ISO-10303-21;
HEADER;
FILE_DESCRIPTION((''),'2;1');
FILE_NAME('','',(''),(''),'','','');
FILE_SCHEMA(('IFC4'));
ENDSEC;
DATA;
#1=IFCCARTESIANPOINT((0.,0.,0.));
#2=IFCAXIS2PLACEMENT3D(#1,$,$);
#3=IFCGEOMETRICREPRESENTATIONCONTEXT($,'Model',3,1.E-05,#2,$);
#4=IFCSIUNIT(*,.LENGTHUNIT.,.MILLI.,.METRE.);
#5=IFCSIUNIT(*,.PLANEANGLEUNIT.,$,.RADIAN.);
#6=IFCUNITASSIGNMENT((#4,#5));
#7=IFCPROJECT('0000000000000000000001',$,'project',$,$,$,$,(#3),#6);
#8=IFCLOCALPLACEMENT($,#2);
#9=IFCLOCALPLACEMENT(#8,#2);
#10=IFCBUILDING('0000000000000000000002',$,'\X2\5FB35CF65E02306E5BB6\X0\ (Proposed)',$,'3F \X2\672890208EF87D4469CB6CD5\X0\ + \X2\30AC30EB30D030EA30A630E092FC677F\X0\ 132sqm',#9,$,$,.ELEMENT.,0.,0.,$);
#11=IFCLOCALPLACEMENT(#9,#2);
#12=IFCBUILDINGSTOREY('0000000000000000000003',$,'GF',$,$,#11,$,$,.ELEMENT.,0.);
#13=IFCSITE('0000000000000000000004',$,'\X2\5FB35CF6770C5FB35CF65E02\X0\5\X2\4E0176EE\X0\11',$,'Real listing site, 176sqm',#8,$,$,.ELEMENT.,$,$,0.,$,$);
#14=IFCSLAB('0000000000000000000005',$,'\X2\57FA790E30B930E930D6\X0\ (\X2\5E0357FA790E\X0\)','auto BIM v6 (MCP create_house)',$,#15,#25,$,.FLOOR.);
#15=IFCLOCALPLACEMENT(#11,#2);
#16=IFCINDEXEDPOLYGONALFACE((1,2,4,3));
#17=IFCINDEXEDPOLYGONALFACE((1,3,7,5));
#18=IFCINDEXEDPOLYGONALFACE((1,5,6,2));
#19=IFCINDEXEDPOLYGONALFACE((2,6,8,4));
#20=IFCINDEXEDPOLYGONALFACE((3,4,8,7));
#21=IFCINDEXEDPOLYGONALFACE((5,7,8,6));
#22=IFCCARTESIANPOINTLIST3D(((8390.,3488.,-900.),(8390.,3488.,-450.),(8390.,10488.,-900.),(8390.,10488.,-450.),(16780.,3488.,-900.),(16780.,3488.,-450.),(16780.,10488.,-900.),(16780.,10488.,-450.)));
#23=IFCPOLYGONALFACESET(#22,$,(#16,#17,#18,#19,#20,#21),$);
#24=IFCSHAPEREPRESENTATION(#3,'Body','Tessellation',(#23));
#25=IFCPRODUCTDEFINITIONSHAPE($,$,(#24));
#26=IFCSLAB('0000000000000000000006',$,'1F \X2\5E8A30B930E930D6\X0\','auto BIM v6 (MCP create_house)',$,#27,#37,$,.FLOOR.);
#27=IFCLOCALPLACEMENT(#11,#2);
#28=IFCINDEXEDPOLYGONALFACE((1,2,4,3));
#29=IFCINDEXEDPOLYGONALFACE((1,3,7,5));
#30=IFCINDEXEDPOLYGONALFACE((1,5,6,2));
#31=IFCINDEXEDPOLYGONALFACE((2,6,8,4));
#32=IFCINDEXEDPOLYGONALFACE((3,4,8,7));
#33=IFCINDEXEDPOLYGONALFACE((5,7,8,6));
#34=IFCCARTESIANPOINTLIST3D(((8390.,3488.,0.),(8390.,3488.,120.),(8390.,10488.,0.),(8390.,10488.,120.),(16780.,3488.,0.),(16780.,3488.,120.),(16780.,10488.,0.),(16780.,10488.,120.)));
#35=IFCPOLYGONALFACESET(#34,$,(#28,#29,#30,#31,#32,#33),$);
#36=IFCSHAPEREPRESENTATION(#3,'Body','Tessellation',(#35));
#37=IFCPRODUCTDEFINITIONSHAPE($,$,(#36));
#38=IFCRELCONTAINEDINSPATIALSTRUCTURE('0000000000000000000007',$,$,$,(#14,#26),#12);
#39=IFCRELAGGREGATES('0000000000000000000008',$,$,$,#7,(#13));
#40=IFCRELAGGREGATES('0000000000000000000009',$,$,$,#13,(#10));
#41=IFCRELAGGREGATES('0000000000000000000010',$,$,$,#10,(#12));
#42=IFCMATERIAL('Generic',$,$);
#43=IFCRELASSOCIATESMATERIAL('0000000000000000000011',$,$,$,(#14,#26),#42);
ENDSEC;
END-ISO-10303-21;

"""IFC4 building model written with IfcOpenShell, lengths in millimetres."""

from ifc_helpers import new_model, si_unit, frame, frame_2d, origin, place, context, project, spatial, rectangle, extrude, material, element, save


model = new_model("IFC4")

# Units and contexts
model_context = context("Model", 3, precision=1e-05, world=origin())
ifc_project = project(units=[si_unit("LENGTHUNIT", "METRE", prefix="MILLI"), si_unit("PLANEANGLEUNIT", "RADIAN")], contexts=[model_context])

# Site, building, storey
site_placement = place(None, origin())
site = spatial("IfcSite", under=ifc_project, at=site_placement, Name="徳島県徳島市5丁目11", ObjectType="Real listing site, 176sqm", CompositionType="ELEMENT", RefElevation=0.0)
building_placement = place(site_placement, origin())
building = spatial("IfcBuilding", under=site, at=building_placement, Name="徳島市の家 (Proposed)", ObjectType="3F 木造軸組構法 + ガルバリウム鋼板 132sqm", CompositionType="ELEMENT", ElevationOfRefHeight=0.0, ElevationOfTerrain=0.0)
storey_placement = place(building_placement, origin())
storey = spatial("IfcBuildingStorey", under=building, at=storey_placement, Name="GF", CompositionType="ELEMENT", Elevation=0.0)

# Slabs
ifc_material = material(Name="Generic")
slab_1_placement = place(storey_placement, frame((4195.0, 1744.0, -450.0)))
element("IfcSlab", 1, at=slab_1_placement, inside=storey, material=ifc_material, Name="基礎スラブ (布基礎)", Description="auto BIM v6 (MCP create_house)", PredefinedType="FLOOR", context=model_context, shape_type="SweptSolid", body=[
    extrude(rectangle(XDim=8390.0, YDim=7000.0, at=frame_2d((4195.0, 3500.0))), frame((4195.0, 1744.0, -450.0)), (0.0, 0.0, 1.0), 450.0),
])
slab_2_placement = place(storey_placement, frame((4195.0, 1744.0, 0.0)))
element("IfcSlab", 2, at=slab_2_placement, inside=storey, material=ifc_material, Name="1F 床スラブ", Description="auto BIM v6 (MCP create_house)", PredefinedType="FLOOR", context=model_context, shape_type="SweptSolid", body=[
    extrude(rectangle(XDim=8390.0, YDim=7000.0, at=frame_2d((4195.0, 3500.0))), frame((4195.0, 1744.0, 0.0)), (0.0, 0.0, 1.0), 120.0),
])

save(model, "model.ifc")
